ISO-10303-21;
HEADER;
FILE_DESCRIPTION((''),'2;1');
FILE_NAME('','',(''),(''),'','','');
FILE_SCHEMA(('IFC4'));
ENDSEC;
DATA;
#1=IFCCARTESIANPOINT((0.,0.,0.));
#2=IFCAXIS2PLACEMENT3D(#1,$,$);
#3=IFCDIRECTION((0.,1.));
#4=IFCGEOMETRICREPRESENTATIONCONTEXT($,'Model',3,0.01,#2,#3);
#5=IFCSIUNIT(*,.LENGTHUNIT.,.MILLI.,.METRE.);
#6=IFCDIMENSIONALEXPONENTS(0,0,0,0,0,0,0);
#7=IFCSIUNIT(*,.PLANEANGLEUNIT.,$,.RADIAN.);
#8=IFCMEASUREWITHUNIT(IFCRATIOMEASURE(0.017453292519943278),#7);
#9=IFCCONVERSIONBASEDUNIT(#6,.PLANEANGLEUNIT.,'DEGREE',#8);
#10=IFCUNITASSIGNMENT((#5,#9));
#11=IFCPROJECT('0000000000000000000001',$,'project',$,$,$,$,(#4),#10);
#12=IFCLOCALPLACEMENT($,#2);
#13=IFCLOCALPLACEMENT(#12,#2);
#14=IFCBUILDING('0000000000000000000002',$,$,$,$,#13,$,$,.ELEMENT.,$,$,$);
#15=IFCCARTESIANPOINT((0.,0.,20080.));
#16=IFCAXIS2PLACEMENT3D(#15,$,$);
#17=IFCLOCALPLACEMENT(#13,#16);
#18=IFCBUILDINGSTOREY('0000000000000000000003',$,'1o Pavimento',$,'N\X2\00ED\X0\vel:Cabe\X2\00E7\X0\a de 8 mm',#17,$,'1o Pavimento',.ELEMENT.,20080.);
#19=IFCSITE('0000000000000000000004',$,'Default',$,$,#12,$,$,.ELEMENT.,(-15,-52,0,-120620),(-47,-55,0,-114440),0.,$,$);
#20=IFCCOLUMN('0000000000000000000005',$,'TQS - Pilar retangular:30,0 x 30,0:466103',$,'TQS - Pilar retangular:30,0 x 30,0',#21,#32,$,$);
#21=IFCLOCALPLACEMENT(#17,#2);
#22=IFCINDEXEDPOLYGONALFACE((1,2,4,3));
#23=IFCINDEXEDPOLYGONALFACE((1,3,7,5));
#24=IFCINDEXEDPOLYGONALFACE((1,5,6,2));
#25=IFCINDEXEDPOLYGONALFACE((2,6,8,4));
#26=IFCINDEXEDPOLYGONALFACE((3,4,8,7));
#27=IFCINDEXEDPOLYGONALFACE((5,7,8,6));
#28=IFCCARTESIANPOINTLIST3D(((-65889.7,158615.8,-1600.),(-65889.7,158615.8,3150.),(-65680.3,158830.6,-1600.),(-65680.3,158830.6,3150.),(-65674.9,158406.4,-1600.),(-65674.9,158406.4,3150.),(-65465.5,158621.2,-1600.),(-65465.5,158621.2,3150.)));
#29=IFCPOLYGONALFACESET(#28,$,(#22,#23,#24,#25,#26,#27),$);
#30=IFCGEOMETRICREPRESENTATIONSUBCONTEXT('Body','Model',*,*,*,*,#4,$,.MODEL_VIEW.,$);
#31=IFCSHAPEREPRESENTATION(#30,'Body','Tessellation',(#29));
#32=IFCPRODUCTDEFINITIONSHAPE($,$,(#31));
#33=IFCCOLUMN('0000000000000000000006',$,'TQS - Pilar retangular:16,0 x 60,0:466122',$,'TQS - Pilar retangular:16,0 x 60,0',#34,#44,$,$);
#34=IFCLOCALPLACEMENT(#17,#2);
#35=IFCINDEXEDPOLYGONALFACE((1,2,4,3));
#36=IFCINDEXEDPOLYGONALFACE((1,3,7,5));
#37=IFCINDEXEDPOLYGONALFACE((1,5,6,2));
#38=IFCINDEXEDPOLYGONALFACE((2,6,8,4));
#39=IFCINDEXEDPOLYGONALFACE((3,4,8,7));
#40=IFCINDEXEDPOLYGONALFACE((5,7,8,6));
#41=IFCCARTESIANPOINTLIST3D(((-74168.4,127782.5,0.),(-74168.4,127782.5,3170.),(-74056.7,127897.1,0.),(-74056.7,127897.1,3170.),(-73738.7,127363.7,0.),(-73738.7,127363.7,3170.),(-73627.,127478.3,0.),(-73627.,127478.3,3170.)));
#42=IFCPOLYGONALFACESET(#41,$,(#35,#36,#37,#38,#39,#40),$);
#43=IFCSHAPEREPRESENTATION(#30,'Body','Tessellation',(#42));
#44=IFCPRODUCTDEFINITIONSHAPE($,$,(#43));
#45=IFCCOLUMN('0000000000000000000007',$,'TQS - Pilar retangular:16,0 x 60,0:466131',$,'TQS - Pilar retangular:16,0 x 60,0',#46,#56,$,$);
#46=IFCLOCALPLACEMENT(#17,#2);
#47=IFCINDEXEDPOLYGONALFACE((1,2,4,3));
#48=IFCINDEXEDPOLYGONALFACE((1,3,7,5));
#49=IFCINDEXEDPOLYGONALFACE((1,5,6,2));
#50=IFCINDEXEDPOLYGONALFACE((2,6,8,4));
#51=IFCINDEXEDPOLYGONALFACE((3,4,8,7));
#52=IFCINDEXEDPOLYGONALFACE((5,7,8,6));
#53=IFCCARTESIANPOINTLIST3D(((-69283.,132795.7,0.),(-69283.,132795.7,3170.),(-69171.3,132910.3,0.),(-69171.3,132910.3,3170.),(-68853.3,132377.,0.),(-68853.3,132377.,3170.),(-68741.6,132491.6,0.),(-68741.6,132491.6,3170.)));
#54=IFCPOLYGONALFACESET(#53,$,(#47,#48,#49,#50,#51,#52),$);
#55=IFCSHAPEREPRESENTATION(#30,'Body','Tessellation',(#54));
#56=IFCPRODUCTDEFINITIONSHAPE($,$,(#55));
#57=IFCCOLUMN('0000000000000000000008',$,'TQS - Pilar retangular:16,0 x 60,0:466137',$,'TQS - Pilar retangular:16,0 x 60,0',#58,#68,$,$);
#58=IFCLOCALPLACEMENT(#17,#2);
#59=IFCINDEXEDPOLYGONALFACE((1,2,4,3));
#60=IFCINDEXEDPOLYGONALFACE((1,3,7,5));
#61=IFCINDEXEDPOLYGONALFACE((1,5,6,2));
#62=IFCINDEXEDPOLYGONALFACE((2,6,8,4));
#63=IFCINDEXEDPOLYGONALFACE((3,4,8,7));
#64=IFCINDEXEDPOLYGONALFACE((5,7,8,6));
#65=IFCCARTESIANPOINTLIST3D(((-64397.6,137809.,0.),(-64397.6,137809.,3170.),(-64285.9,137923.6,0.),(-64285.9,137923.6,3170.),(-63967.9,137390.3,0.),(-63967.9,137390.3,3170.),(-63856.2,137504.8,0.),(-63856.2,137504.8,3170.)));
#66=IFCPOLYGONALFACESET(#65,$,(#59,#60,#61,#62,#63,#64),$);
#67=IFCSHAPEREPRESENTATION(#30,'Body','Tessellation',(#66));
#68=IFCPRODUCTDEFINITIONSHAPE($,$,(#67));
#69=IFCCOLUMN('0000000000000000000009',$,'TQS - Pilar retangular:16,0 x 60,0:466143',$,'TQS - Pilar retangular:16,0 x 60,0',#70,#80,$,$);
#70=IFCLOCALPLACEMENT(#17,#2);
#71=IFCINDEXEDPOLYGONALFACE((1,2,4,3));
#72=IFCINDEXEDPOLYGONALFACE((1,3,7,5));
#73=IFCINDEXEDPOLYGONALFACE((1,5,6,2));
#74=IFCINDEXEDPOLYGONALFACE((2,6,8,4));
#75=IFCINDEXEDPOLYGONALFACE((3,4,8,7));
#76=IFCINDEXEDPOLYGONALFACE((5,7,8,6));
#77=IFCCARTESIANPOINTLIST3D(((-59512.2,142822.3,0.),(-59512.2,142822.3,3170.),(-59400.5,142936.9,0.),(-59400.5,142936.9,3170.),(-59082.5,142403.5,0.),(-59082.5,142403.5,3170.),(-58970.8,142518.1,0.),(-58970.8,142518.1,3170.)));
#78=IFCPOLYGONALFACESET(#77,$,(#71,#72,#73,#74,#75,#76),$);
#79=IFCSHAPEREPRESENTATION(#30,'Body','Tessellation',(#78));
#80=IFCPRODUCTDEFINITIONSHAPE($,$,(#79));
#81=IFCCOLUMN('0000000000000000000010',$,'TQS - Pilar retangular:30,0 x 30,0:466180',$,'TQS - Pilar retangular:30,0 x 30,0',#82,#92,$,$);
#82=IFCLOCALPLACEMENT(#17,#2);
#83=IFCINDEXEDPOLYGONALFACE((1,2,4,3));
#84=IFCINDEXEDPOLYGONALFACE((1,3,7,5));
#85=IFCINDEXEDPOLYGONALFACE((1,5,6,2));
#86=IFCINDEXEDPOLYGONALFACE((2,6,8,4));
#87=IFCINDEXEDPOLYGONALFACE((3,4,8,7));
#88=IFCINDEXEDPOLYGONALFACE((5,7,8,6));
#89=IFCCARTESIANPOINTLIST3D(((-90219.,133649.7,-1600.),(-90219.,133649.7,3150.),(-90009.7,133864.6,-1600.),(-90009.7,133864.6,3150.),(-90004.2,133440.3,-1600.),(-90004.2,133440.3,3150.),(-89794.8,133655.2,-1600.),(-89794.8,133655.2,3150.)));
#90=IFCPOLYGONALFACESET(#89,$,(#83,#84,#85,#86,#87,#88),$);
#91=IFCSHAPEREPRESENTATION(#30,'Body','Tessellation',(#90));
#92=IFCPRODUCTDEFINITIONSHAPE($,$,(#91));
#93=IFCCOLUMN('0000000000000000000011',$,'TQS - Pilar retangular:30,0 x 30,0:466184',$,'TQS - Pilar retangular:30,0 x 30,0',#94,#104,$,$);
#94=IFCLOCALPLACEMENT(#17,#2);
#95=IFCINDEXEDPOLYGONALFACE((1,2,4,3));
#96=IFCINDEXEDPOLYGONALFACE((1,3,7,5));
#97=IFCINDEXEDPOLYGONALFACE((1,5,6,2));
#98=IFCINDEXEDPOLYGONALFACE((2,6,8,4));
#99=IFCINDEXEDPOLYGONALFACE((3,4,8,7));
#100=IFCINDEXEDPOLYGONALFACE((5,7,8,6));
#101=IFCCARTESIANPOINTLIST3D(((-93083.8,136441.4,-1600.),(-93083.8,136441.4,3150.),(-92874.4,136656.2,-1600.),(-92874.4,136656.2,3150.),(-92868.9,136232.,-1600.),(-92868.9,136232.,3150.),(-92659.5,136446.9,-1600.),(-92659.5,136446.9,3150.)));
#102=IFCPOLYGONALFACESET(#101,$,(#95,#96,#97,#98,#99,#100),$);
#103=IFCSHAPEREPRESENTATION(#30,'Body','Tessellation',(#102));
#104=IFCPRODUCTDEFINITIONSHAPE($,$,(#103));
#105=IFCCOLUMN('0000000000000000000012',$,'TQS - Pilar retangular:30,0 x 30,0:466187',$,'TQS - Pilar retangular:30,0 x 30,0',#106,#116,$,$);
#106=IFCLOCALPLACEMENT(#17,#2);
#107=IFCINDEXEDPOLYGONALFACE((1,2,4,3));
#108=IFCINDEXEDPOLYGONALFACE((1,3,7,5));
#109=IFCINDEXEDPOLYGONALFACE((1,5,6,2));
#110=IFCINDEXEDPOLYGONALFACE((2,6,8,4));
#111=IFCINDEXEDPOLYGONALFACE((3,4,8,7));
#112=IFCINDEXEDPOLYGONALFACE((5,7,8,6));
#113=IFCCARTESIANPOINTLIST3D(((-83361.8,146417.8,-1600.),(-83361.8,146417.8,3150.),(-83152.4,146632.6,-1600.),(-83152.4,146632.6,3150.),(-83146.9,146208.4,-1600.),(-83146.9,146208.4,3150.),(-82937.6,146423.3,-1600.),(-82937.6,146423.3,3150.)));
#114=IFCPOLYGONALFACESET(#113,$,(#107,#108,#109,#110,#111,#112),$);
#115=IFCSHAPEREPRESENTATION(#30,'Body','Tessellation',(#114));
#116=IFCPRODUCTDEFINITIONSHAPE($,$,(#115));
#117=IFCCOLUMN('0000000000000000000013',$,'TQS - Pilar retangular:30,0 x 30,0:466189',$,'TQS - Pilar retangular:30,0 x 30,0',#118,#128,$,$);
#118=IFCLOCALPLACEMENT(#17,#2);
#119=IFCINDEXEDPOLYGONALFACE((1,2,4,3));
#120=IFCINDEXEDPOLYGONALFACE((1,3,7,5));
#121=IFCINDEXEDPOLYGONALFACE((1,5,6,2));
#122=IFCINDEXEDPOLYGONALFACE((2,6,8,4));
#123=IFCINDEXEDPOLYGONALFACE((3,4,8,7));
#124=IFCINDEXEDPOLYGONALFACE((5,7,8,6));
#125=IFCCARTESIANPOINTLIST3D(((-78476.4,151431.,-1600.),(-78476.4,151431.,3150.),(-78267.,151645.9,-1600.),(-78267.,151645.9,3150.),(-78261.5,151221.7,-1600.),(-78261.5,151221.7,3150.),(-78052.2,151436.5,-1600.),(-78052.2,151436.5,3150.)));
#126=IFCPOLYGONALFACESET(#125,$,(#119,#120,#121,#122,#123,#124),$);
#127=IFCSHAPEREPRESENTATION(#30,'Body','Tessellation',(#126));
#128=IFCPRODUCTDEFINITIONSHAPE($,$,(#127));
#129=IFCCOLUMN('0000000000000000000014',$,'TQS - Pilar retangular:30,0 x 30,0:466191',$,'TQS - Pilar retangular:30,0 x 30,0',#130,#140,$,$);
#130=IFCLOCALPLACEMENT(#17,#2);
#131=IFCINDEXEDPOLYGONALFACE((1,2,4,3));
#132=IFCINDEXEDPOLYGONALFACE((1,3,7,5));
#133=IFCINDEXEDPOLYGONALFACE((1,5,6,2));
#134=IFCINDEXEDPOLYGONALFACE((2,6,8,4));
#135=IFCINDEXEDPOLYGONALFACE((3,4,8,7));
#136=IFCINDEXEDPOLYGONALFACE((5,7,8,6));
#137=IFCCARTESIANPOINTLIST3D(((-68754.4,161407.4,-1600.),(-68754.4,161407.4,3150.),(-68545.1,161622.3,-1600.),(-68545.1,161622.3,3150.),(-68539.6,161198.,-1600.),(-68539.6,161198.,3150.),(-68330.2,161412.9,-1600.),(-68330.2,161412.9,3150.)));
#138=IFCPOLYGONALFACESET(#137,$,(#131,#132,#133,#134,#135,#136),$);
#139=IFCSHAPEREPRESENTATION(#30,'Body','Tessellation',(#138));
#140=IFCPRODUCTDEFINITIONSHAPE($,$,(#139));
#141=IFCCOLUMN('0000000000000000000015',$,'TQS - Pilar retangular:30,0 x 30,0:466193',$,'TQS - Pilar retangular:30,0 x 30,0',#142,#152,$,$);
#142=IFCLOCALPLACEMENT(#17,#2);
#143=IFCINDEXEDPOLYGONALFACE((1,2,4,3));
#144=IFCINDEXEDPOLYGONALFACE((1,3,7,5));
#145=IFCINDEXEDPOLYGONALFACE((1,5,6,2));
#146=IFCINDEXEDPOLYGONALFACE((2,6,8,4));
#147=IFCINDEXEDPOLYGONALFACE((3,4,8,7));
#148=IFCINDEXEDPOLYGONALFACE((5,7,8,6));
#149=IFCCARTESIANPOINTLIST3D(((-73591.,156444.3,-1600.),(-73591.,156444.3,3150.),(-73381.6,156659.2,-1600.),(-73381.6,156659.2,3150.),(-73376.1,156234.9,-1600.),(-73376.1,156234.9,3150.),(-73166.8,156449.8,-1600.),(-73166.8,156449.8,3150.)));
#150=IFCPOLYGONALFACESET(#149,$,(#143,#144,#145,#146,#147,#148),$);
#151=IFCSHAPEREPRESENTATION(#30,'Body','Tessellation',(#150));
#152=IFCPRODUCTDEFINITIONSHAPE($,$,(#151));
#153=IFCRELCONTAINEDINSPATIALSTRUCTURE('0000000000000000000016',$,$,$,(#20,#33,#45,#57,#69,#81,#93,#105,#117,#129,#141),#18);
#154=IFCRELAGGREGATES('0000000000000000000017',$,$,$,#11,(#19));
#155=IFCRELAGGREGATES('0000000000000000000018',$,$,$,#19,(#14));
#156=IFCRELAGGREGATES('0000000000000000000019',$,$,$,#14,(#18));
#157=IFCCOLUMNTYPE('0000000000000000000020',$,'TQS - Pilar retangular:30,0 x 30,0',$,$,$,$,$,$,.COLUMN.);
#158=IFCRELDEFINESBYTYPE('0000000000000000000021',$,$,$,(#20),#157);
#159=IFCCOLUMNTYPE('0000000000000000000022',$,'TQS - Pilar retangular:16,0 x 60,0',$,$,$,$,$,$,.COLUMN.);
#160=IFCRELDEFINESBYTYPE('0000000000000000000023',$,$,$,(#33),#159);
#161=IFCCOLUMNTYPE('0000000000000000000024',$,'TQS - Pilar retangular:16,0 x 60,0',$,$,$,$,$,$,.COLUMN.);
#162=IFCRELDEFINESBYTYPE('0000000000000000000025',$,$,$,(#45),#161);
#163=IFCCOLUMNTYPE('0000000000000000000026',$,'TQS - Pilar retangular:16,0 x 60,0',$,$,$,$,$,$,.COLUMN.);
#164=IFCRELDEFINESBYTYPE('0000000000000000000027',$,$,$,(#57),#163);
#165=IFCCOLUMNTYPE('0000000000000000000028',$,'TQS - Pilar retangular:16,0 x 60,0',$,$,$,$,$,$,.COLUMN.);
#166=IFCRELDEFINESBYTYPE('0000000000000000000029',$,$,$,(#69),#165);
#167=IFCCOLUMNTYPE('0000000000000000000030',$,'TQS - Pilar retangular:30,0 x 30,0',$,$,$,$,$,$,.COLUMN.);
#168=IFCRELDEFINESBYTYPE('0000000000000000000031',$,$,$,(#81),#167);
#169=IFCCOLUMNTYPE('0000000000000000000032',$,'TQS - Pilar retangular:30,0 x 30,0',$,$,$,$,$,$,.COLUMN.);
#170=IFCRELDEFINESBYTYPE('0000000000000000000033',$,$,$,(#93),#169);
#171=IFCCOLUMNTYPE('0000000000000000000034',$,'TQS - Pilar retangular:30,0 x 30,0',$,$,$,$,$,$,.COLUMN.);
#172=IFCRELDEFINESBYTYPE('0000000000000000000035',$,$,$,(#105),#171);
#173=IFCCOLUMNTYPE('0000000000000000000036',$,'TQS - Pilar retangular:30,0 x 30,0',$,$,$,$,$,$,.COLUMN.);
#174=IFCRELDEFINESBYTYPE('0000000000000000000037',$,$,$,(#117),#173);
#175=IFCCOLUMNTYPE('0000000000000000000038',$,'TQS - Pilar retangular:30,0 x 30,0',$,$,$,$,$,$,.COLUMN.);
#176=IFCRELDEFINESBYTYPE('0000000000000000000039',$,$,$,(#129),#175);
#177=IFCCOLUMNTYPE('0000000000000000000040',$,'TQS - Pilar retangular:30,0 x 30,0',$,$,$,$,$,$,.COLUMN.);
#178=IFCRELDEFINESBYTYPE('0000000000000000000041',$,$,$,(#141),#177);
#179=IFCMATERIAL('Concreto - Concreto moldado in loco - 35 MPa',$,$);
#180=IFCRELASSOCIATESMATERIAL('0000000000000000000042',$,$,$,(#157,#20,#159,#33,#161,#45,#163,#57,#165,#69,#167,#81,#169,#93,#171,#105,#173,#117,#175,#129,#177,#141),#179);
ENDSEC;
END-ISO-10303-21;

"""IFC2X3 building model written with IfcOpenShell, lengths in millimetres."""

from ifc_helpers import new_model, entity, si_unit, converted_unit, direction, frame, frame_2d, origin, origin_2d_with_axis, place, context, subcontext, project, spatial, rectangle, extrude, source, transform, mapped, material, type_object, type_shapes, element, save


model = new_model("IFC2X3")

# Units and contexts
model_context = context("Model", 3, precision=0.01, world=origin(), true_north=direction((0.0, 1.0)))
body_context = subcontext(model_context, "Body", "Model", "MODEL_VIEW")
ifc_project = project(units=[si_unit("LENGTHUNIT", "METRE", prefix="MILLI"), converted_unit("PLANEANGLEUNIT", "DEGREE", entity("IfcRatioMeasure", 0.017453292519943278), si_unit("PLANEANGLEUNIT", "RADIAN"), dimensions=[0, 0, 0, 0, 0, 0, 0])], contexts=[model_context])

# Site, building, storey
site_placement = place(None, origin())
site = spatial("IfcSite", under=ifc_project, at=site_placement, Name="Default", CompositionType="ELEMENT", RefLatitude=(-15, -52, 0, -120620), RefLongitude=(-47, -55, 0, -114440), RefElevation=0.0)
building_placement = place(site_placement, origin())
building = spatial("IfcBuilding", under=site, at=building_placement, CompositionType="ELEMENT")
storey_placement = place(building_placement, frame((0.0, 0.0, 20080.0)))
storey = spatial("IfcBuildingStorey", under=building, at=storey_placement, Name="1o Pavimento", ObjectType="Nível:Cabeça de 8 mm", LongName="1o Pavimento", CompositionType="ELEMENT", Elevation=20080.0)

# Columns
ifc_material = material(Name="Concreto - Concreto moldado in loco - 35 MPa")
column_type_1 = type_object("IfcColumnType", Name="TQS - Pilar retangular:30,0 x 30,0", PredefinedType="COLUMN", material=ifc_material)
shared_shape_1 = source(origin(), body_context, "Body", "SweptSolid", [
    extrude(rectangle(XDim=300.0, YDim=300.0, at=origin_2d_with_axis()), frame((-65677.6, 158618.5, 18480.0), z_axis=(0.0, 0.0, 1.0), x_axis=(-0.71618, 0.697915, 0.0)), (0.0, 0.0, 1.0), 4750.0),
])
type_shapes(column_type_1, [shared_shape_1])
column_1_placement = place(storey_placement, frame((0.0, 0.0, -20080.0)))
element("IfcColumn", 1, at=column_1_placement, inside=storey, type_object=column_type_1, material=ifc_material, Name="TQS - Pilar retangular:30,0 x 30,0:466103", ObjectType="TQS - Pilar retangular:30,0 x 30,0", context=body_context, shape_type="MappedRepresentation", body=[
    mapped(shared_shape_1, transform((0.0, 0.0, 0.0), scale=1.0)),
])
column_type_2 = type_object("IfcColumnType", Name="TQS - Pilar retangular:16,0 x 60,0", PredefinedType="COLUMN", material=ifc_material)
shared_shape_2 = source(origin(), body_context, "Body", "SweptSolid", [
    extrude(rectangle(XDim=600.0, YDim=160.0, at=frame_2d((0.0, 0.0), x_axis=(1.0, 0.0))), frame((-73897.7, 127630.4, 20080.0), z_axis=(0.0, 0.0, 1.0), x_axis=(-0.71618, 0.697915, 0.0)), (0.0, 0.0, 1.0), 3170.0),
])
type_shapes(column_type_2, [shared_shape_2])
column_2_placement = place(storey_placement, frame((0.0, 0.0, -20080.0)))
element("IfcColumn", 2, at=column_2_placement, inside=storey, type_object=column_type_2, material=ifc_material, Name="TQS - Pilar retangular:16,0 x 60,0:466122", ObjectType="TQS - Pilar retangular:16,0 x 60,0", context=body_context, shape_type="MappedRepresentation", body=[
    mapped(shared_shape_2, transform((0.0, 0.0, 0.0), scale=1.0)),
])
column_type_3 = type_object("IfcColumnType", Name="TQS - Pilar retangular:16,0 x 60,0", PredefinedType="COLUMN", material=ifc_material)
shared_shape_3 = source(origin(), body_context, "Body", "SweptSolid", [
    extrude(rectangle(XDim=600.0, YDim=160.0, at=frame_2d((0.0, 0.0), x_axis=(1.0, 0.0))), frame((-69012.3, 132643.7, 20080.0), z_axis=(0.0, 0.0, 1.0), x_axis=(-0.71618, 0.697915, 0.0)), (0.0, 0.0, 1.0), 3170.0),
])
type_shapes(column_type_3, [shared_shape_3])
column_3_placement = place(storey_placement, frame((0.0, 0.0, -20080.0)))
element("IfcColumn", 3, at=column_3_placement, inside=storey, type_object=column_type_3, material=ifc_material, Name="TQS - Pilar retangular:16,0 x 60,0:466131", ObjectType="TQS - Pilar retangular:16,0 x 60,0", context=body_context, shape_type="MappedRepresentation", body=[
    mapped(shared_shape_3, transform((0.0, 0.0, 0.0), scale=1.0)),
])
column_type_4 = type_object("IfcColumnType", Name="TQS - Pilar retangular:16,0 x 60,0", PredefinedType="COLUMN", material=ifc_material)
shared_shape_4 = source(origin(), body_context, "Body", "SweptSolid", [
    extrude(rectangle(XDim=600.0, YDim=160.0, at=frame_2d((0.0, 0.0), x_axis=(1.0, 0.0))), frame((-64126.9, 137656.9, 20080.0), z_axis=(0.0, 0.0, 1.0), x_axis=(-0.71618, 0.697915, 0.0)), (0.0, 0.0, 1.0), 3170.0),
])
type_shapes(column_type_4, [shared_shape_4])
column_4_placement = place(storey_placement, frame((0.0, 0.0, -20080.0)))
element("IfcColumn", 4, at=column_4_placement, inside=storey, type_object=column_type_4, material=ifc_material, Name="TQS - Pilar retangular:16,0 x 60,0:466137", ObjectType="TQS - Pilar retangular:16,0 x 60,0", context=body_context, shape_type="MappedRepresentation", body=[
    mapped(shared_shape_4, transform((0.0, 0.0, 0.0), scale=1.0)),
])
column_type_5 = type_object("IfcColumnType", Name="TQS - Pilar retangular:16,0 x 60,0", PredefinedType="COLUMN", material=ifc_material)
shared_shape_5 = source(origin(), body_context, "Body", "SweptSolid", [
    extrude(rectangle(XDim=600.0, YDim=160.0, at=frame_2d((0.0, 0.0), x_axis=(1.0, 0.0))), frame((-59241.5, 142670.2, 20080.0), z_axis=(0.0, 0.0, 1.0), x_axis=(-0.71618, 0.697915, 0.0)), (0.0, 0.0, 1.0), 3170.0),
])
type_shapes(column_type_5, [shared_shape_5])
column_5_placement = place(storey_placement, frame((0.0, 0.0, -20080.0)))
element("IfcColumn", 5, at=column_5_placement, inside=storey, type_object=column_type_5, material=ifc_material, Name="TQS - Pilar retangular:16,0 x 60,0:466143", ObjectType="TQS - Pilar retangular:16,0 x 60,0", context=body_context, shape_type="MappedRepresentation", body=[
    mapped(shared_shape_5, transform((0.0, 0.0, 0.0), scale=1.0)),
])
column_type_6 = type_object("IfcColumnType", Name="TQS - Pilar retangular:30,0 x 30,0", PredefinedType="COLUMN", material=ifc_material)
shared_shape_6 = source(origin(), body_context, "Body", "SweptSolid", [
    extrude(rectangle(XDim=300.0, YDim=300.0, at=origin_2d_with_axis()), frame((-90006.9, 133652.5, 18480.0), z_axis=(0.0, 0.0, 1.0), x_axis=(-0.71618, 0.697915, 0.0)), (0.0, 0.0, 1.0), 4750.0),
])
type_shapes(column_type_6, [shared_shape_6])
column_6_placement = place(storey_placement, frame((0.0, 0.0, -20080.0)))
element("IfcColumn", 6, at=column_6_placement, inside=storey, type_object=column_type_6, material=ifc_material, Name="TQS - Pilar retangular:30,0 x 30,0:466180", ObjectType="TQS - Pilar retangular:30,0 x 30,0", context=body_context, shape_type="MappedRepresentation", body=[
    mapped(shared_shape_6, transform((0.0, 0.0, 0.0), scale=1.0)),
])
column_type_7 = type_object("IfcColumnType", Name="TQS - Pilar retangular:30,0 x 30,0", PredefinedType="COLUMN", material=ifc_material)
shared_shape_7 = source(origin(), body_context, "Body", "SweptSolid", [
    extrude(rectangle(XDim=300.0, YDim=300.0, at=origin_2d_with_axis()), frame((-92871.7, 136444.1, 18480.0), z_axis=(0.0, 0.0, 1.0), x_axis=(-0.71618, 0.697915, 0.0)), (0.0, 0.0, 1.0), 4750.0),
])
type_shapes(column_type_7, [shared_shape_7])
column_7_placement = place(storey_placement, frame((0.0, 0.0, -20080.0)))
element("IfcColumn", 7, at=column_7_placement, inside=storey, type_object=column_type_7, material=ifc_material, Name="TQS - Pilar retangular:30,0 x 30,0:466184", ObjectType="TQS - Pilar retangular:30,0 x 30,0", context=body_context, shape_type="MappedRepresentation", body=[
    mapped(shared_shape_7, transform((0.0, 0.0, 0.0), scale=1.0)),
])
column_type_8 = type_object("IfcColumnType", Name="TQS - Pilar retangular:30,0 x 30,0", PredefinedType="COLUMN", material=ifc_material)
shared_shape_8 = source(origin(), body_context, "Body", "SweptSolid", [
    extrude(rectangle(XDim=300.0, YDim=300.0, at=origin_2d_with_axis()), frame((-83149.7, 146420.5, 18480.0), z_axis=(0.0, 0.0, 1.0), x_axis=(-0.71618, 0.697915, 0.0)), (0.0, 0.0, 1.0), 4750.0),
])
type_shapes(column_type_8, [shared_shape_8])
column_8_placement = place(storey_placement, frame((0.0, 0.0, -20080.0)))
element("IfcColumn", 8, at=column_8_placement, inside=storey, type_object=column_type_8, material=ifc_material, Name="TQS - Pilar retangular:30,0 x 30,0:466187", ObjectType="TQS - Pilar retangular:30,0 x 30,0", context=body_context, shape_type="MappedRepresentation", body=[
    mapped(shared_shape_8, transform((0.0, 0.0, 0.0), scale=1.0)),
])
column_type_9 = type_object("IfcColumnType", Name="TQS - Pilar retangular:30,0 x 30,0", PredefinedType="COLUMN", material=ifc_material)
shared_shape_9 = source(origin(), body_context, "Body", "SweptSolid", [
    extrude(rectangle(XDim=300.0, YDim=300.0, at=origin_2d_with_axis()), frame((-78264.3, 151433.8, 18480.0), z_axis=(0.0, 0.0, 1.0), x_axis=(-0.71618, 0.697915, 0.0)), (0.0, 0.0, 1.0), 4750.0),
])
type_shapes(column_type_9, [shared_shape_9])
column_9_placement = place(storey_placement, frame((0.0, 0.0, -20080.0)))
element("IfcColumn", 9, at=column_9_placement, inside=storey, type_object=column_type_9, material=ifc_material, Name="TQS - Pilar retangular:30,0 x 30,0:466189", ObjectType="TQS - Pilar retangular:30,0 x 30,0", context=body_context, shape_type="MappedRepresentation", body=[
    mapped(shared_shape_9, transform((0.0, 0.0, 0.0), scale=1.0)),
])
column_type_10 = type_object("IfcColumnType", Name="TQS - Pilar retangular:30,0 x 30,0", PredefinedType="COLUMN", material=ifc_material)
shared_shape_10 = source(origin(), body_context, "Body", "SweptSolid", [
    extrude(rectangle(XDim=300.0, YDim=300.0, at=origin_2d_with_axis()), frame((-68542.3, 161410.2, 18480.0), z_axis=(0.0, 0.0, 1.0), x_axis=(-0.71618, 0.697915, 0.0)), (0.0, 0.0, 1.0), 4750.0),
])
type_shapes(column_type_10, [shared_shape_10])
column_10_placement = place(storey_placement, frame((0.0, 0.0, -20080.0)))
element("IfcColumn", 10, at=column_10_placement, inside=storey, type_object=column_type_10, material=ifc_material, Name="TQS - Pilar retangular:30,0 x 30,0:466191", ObjectType="TQS - Pilar retangular:30,0 x 30,0", context=body_context, shape_type="MappedRepresentation", body=[
    mapped(shared_shape_10, transform((0.0, 0.0, 0.0), scale=1.0)),
])
column_type_11 = type_object("IfcColumnType", Name="TQS - Pilar retangular:30,0 x 30,0", PredefinedType="COLUMN", material=ifc_material)
shared_shape_11 = source(origin(), body_context, "Body", "SweptSolid", [
    extrude(rectangle(XDim=300.0, YDim=300.0, at=origin_2d_with_axis()), frame((-73378.9, 156447.0, 18480.0), z_axis=(0.0, 0.0, 1.0), x_axis=(-0.71618, 0.697915, 0.0)), (0.0, 0.0, 1.0), 4750.0),
])
type_shapes(column_type_11, [shared_shape_11])
column_11_placement = place(storey_placement, frame((0.0, 0.0, -20080.0)))
element("IfcColumn", 11, at=column_11_placement, inside=storey, type_object=column_type_11, material=ifc_material, Name="TQS - Pilar retangular:30,0 x 30,0:466193", ObjectType="TQS - Pilar retangular:30,0 x 30,0", context=body_context, shape_type="MappedRepresentation", body=[
    mapped(shared_shape_11, transform((0.0, 0.0, 0.0), scale=1.0)),
])

save(model, "model.ifc")
